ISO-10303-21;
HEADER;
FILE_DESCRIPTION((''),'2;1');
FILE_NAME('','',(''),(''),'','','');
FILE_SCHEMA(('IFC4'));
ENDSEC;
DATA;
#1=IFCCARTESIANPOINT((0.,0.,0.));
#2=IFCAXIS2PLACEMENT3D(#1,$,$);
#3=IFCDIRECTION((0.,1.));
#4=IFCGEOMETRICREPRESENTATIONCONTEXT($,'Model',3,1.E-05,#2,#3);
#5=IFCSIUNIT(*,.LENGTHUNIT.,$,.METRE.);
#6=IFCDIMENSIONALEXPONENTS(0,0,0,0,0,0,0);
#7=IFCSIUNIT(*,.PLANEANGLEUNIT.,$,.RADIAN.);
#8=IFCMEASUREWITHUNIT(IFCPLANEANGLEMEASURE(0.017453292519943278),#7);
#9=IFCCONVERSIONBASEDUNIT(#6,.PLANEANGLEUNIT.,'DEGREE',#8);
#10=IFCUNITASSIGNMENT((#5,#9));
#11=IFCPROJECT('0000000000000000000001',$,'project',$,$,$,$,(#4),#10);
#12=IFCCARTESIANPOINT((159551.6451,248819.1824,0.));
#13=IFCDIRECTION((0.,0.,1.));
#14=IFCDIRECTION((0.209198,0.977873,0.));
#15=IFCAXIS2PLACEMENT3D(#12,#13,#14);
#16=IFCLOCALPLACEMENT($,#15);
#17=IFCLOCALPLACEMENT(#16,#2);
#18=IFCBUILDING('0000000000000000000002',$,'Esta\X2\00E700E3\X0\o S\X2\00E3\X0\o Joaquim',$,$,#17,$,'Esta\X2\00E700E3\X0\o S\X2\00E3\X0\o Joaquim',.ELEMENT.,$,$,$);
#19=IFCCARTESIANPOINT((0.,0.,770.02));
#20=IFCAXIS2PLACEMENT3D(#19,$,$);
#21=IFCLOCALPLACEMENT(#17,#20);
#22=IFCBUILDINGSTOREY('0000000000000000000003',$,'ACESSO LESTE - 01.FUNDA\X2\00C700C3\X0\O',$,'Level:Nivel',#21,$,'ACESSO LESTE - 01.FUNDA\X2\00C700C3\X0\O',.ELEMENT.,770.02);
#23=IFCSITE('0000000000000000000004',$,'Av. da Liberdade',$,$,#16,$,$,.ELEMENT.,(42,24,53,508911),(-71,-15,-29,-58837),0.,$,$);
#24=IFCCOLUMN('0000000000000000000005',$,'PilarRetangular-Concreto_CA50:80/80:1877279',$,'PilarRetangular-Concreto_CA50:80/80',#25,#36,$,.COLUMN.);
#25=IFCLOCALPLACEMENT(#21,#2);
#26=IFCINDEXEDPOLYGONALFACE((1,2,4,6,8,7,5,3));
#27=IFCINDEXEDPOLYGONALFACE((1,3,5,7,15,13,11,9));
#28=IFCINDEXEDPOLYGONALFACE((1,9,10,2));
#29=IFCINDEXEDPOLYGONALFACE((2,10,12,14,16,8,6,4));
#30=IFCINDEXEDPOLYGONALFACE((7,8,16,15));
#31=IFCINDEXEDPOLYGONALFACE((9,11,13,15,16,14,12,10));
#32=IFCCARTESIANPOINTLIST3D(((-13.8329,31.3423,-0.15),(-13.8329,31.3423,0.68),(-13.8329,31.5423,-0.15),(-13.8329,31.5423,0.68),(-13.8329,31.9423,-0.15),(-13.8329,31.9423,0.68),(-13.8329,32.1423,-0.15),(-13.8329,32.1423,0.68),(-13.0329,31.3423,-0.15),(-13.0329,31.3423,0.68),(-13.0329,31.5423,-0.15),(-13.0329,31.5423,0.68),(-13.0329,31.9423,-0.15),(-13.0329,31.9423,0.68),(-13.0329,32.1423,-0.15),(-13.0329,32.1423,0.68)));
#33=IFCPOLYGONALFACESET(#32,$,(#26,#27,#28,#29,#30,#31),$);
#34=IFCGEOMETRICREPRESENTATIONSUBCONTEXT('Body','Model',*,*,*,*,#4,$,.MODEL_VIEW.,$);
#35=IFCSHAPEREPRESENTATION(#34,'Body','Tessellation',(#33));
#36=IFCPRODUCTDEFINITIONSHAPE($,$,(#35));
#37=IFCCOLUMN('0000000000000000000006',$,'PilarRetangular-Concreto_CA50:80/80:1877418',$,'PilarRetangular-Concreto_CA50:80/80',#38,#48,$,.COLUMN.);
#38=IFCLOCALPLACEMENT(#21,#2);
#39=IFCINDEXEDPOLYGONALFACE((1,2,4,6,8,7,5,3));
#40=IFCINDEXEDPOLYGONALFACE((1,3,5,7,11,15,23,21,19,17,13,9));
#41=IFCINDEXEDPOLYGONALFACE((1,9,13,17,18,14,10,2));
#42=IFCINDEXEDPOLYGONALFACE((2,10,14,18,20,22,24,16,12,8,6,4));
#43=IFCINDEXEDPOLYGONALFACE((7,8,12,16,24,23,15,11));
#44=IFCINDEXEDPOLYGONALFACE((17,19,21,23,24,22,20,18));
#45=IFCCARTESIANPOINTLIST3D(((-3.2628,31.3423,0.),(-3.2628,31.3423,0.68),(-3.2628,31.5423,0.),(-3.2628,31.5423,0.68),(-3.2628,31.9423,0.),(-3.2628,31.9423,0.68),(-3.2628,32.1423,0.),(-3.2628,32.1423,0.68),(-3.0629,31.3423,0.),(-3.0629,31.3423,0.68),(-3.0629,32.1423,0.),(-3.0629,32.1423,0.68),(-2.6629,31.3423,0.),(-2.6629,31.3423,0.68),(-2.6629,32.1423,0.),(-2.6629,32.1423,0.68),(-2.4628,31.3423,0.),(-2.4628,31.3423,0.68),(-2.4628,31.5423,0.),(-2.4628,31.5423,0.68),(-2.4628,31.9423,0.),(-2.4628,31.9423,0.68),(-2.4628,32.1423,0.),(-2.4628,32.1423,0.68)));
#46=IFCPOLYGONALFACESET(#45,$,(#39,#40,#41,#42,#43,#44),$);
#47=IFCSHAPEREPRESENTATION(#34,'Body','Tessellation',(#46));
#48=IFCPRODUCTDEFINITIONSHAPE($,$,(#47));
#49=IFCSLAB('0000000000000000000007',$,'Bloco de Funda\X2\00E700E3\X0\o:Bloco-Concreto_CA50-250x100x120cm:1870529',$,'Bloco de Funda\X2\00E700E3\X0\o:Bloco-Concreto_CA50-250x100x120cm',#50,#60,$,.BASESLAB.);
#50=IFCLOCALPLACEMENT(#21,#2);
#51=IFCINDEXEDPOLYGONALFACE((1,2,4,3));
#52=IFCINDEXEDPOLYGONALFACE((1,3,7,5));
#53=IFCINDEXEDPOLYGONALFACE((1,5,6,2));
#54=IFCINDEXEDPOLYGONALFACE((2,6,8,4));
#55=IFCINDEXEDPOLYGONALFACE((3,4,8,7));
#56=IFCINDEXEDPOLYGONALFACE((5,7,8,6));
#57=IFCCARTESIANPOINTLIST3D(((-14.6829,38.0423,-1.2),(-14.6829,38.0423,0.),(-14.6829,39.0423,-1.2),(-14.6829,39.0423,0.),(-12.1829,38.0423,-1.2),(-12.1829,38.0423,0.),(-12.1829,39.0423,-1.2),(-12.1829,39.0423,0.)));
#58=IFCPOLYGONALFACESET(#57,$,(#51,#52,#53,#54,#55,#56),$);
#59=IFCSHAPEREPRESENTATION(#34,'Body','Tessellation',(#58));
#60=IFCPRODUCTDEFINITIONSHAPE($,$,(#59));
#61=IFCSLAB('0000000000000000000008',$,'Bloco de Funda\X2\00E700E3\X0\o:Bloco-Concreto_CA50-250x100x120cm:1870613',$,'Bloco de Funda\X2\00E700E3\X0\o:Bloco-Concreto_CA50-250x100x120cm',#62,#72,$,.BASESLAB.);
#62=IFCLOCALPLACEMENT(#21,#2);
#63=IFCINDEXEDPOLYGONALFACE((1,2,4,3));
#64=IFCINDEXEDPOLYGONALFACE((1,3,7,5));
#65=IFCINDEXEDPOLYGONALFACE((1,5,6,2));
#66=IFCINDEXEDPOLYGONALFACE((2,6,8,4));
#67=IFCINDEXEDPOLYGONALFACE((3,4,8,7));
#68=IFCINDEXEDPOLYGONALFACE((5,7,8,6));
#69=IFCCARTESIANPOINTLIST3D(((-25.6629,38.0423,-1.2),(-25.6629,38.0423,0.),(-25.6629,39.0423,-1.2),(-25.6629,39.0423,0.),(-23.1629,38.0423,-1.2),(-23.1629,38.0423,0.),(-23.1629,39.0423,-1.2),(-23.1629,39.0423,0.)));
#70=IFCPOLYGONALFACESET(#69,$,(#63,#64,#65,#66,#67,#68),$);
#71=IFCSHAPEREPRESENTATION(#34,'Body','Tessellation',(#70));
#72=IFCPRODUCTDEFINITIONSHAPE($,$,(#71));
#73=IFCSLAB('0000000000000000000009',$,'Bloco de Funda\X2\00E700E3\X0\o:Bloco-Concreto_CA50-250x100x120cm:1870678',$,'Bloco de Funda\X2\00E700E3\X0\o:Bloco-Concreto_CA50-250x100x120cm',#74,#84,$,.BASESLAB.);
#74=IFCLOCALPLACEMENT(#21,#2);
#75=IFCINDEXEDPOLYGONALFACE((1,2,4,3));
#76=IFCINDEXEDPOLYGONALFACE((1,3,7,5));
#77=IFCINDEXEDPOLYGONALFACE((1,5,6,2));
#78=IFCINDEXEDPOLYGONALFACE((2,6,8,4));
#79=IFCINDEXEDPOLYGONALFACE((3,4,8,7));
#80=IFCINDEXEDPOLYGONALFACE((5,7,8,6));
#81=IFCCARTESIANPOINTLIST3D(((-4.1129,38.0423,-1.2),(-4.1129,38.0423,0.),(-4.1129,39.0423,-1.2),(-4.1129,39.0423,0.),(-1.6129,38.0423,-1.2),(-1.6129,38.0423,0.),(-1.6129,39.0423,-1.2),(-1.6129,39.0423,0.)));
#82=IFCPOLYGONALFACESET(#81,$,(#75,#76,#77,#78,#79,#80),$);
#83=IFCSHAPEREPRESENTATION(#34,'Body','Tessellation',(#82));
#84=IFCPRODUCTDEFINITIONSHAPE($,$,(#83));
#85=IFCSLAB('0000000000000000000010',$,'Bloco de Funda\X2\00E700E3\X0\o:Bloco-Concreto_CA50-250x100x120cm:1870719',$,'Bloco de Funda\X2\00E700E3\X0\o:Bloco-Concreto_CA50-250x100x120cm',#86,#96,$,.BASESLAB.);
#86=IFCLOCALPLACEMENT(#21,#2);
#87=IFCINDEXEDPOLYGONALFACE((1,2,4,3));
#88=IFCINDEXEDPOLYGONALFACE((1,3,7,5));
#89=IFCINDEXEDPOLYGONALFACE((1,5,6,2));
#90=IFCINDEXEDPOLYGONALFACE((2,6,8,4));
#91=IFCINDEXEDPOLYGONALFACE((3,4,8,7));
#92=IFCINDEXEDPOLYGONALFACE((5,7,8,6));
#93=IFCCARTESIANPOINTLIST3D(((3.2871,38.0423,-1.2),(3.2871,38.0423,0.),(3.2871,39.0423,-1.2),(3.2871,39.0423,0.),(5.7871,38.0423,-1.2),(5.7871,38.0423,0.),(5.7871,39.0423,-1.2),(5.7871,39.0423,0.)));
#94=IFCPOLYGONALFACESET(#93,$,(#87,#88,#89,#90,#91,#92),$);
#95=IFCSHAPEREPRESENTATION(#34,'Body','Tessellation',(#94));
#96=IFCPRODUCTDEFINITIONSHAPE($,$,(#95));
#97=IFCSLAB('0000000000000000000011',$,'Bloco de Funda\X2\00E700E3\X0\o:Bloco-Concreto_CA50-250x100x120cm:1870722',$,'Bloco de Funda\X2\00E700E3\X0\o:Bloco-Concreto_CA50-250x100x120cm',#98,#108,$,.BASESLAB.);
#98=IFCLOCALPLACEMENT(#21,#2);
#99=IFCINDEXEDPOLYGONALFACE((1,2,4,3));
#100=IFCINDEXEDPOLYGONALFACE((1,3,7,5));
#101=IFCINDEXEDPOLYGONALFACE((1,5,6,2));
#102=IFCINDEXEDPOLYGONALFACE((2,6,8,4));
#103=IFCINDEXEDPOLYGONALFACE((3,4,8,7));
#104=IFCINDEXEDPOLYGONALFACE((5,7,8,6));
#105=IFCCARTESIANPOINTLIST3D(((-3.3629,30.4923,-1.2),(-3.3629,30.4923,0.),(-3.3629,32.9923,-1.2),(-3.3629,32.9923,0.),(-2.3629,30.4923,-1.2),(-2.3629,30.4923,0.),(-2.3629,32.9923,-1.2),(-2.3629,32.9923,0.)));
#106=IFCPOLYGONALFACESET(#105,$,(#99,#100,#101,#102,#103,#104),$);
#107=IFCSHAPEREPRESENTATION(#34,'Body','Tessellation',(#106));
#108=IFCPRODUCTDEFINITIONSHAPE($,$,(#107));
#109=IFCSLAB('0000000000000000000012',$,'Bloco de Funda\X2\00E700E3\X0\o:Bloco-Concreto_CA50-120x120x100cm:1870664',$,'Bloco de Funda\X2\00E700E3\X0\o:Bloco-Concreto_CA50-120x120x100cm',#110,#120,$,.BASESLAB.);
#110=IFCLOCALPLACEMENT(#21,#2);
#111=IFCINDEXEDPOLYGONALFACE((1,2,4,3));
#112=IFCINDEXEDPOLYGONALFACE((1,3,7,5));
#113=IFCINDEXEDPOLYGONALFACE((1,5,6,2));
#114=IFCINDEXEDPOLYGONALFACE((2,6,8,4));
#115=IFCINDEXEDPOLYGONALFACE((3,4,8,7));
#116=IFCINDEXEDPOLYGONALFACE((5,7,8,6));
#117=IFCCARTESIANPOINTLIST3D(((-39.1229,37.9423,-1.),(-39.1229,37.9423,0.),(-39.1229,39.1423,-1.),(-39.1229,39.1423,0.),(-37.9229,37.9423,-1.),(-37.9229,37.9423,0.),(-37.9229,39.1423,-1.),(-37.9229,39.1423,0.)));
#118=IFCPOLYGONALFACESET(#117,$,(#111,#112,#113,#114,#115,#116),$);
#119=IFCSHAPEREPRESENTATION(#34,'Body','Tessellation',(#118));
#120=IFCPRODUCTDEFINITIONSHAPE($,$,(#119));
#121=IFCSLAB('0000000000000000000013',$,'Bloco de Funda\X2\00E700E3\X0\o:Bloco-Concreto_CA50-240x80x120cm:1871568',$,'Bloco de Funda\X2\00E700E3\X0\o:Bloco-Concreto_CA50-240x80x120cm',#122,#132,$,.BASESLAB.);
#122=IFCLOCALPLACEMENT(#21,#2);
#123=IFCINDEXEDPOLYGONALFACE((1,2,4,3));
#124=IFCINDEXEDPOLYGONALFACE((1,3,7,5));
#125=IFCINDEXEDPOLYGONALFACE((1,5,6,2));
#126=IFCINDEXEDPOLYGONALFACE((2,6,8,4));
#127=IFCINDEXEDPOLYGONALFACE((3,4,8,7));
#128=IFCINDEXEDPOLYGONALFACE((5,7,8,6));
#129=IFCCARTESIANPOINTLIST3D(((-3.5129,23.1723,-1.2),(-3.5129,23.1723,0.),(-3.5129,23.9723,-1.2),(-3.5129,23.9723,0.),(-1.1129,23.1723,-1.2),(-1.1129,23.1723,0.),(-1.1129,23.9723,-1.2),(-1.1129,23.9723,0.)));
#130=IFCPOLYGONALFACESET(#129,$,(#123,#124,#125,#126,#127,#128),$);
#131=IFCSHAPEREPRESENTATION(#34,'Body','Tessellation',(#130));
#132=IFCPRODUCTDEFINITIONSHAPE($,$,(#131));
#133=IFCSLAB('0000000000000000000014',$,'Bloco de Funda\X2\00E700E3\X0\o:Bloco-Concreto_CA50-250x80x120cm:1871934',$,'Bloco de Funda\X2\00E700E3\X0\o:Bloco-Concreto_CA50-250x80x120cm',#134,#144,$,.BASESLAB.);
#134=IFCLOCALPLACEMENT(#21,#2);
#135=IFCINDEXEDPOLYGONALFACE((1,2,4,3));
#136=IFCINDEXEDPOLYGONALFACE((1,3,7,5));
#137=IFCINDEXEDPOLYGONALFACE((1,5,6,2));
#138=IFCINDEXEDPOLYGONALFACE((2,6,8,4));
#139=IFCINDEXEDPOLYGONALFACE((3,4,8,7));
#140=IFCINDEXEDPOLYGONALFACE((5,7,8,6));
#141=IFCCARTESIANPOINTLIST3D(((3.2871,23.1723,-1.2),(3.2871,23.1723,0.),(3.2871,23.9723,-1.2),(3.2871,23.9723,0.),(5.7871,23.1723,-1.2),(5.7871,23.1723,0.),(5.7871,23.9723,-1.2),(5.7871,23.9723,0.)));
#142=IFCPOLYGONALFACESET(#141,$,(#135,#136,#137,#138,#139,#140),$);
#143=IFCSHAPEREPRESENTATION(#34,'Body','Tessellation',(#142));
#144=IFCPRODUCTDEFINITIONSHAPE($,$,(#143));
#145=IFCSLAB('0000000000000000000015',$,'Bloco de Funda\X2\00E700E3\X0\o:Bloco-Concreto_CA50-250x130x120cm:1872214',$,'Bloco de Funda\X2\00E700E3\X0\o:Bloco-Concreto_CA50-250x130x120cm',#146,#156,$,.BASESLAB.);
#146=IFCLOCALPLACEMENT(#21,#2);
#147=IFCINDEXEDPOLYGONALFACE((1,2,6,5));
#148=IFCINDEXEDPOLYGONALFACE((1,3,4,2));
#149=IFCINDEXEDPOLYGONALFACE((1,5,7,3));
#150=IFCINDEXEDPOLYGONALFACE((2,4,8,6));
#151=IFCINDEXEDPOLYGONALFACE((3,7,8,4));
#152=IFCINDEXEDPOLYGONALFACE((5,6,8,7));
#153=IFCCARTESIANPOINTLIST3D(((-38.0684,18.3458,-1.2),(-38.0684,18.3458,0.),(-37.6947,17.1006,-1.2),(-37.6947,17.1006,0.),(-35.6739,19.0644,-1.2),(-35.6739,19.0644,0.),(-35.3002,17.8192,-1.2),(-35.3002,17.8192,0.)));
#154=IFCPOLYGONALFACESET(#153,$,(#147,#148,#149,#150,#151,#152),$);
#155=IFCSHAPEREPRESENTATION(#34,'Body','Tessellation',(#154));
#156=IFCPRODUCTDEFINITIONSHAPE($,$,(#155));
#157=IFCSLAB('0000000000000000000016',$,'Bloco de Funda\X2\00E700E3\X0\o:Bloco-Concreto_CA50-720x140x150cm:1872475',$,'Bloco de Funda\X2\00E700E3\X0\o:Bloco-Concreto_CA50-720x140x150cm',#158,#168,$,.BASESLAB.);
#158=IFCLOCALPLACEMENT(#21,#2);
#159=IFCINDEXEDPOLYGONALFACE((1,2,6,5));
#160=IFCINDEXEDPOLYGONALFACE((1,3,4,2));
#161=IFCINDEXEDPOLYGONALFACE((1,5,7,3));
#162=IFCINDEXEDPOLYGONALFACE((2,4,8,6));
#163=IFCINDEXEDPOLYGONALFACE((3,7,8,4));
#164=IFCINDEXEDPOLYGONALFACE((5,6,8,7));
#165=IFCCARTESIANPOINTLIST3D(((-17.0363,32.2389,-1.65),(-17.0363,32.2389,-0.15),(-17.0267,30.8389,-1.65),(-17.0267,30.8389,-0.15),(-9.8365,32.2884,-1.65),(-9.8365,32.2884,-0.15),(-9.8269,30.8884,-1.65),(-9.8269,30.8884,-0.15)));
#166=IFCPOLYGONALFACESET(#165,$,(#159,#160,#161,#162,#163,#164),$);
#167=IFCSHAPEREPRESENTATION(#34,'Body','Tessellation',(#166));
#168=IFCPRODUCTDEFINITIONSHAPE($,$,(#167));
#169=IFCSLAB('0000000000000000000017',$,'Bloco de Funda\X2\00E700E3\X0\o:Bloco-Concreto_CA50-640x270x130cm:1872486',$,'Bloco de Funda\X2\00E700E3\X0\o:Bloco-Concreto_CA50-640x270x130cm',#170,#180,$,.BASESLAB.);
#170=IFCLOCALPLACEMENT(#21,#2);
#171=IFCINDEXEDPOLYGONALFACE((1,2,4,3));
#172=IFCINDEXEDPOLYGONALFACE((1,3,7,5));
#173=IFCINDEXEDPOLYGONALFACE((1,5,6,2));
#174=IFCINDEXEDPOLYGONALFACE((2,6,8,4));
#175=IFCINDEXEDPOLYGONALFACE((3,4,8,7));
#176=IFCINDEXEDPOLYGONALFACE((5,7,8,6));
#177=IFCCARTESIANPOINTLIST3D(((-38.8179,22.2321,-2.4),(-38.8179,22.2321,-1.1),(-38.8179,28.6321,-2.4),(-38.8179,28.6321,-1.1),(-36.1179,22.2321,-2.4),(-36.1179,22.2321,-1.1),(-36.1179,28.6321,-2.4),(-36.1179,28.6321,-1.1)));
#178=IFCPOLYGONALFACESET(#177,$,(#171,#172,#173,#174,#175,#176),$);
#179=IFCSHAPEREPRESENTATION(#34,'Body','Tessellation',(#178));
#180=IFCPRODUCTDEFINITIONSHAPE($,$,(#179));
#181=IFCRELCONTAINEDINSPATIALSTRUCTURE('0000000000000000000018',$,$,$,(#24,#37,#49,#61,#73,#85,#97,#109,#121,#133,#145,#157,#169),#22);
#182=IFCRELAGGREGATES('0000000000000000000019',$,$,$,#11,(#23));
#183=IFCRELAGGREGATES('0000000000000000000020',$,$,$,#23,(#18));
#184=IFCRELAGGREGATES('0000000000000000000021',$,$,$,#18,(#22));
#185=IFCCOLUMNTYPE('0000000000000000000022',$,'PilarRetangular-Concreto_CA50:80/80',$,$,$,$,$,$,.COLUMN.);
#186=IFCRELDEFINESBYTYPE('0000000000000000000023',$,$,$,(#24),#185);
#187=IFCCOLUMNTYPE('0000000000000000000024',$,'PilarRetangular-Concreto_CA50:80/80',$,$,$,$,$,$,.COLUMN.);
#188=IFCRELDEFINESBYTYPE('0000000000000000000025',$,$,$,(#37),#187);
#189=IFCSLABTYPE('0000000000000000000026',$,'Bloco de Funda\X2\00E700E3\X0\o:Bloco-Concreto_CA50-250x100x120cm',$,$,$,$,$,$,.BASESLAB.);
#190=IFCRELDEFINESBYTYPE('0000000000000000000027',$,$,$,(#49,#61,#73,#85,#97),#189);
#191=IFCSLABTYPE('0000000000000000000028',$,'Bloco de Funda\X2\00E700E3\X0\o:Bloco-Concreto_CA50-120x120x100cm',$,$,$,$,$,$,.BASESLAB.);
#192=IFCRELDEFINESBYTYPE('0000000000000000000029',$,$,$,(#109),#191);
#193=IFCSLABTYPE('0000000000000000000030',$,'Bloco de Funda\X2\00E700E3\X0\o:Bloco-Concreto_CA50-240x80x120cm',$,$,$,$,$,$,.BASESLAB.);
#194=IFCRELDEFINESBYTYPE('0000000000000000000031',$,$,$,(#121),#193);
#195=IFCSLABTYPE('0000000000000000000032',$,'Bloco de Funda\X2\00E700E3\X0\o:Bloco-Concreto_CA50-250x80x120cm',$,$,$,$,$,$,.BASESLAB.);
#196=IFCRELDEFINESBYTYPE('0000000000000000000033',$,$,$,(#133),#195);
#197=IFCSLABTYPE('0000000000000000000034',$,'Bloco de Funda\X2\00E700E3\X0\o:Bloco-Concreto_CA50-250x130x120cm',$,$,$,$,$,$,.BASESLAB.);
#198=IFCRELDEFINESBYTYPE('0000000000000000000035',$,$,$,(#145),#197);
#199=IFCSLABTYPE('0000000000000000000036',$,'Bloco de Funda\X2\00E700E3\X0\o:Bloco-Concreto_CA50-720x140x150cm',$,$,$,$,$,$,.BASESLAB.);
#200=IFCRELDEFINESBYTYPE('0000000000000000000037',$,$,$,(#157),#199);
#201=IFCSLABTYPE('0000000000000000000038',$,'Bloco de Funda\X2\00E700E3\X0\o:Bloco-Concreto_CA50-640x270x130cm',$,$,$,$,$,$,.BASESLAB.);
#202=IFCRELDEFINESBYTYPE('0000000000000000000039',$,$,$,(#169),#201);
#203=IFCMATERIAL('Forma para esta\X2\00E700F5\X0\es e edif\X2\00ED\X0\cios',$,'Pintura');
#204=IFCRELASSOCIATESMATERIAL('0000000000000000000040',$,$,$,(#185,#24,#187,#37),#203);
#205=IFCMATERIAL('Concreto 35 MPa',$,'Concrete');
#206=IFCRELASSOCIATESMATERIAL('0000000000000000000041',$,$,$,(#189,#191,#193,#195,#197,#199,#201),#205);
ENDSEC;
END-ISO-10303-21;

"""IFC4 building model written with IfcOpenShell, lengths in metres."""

from ifc_helpers import new_model, entity, si_unit, converted_unit, direction, frame, origin, place, context, subcontext, project, spatial, indexed_curve, outline, extrude, source, transform, mapped, material, type_object, type_shapes, element, save


model = new_model("IFC4")

# Units and contexts
model_context = context("Model", 3, precision=1e-05, world=origin(), true_north=direction((0.0, 1.0)))
body_context = subcontext(model_context, "Body", "Model", "MODEL_VIEW")
ifc_project = project(units=[si_unit("LENGTHUNIT", "METRE"), converted_unit("PLANEANGLEUNIT", "DEGREE", entity("IfcPlaneAngleMeasure", 0.017453292519943278), si_unit("PLANEANGLEUNIT", "RADIAN"), dimensions=[0, 0, 0, 0, 0, 0, 0])], contexts=[model_context])

# Site, building, storey
site_placement = place(None, frame((159551.6451, 248819.1824, 0.0), z_axis=(0.0, 0.0, 1.0), x_axis=(0.209198, 0.977873, 0.0)))
site = spatial("IfcSite", under=ifc_project, at=site_placement, Name="Av. da Liberdade", CompositionType="ELEMENT", RefLatitude=(42, 24, 53, 508911), RefLongitude=(-71, -15, -29, -58837), RefElevation=0.0)
building_placement = place(site_placement, origin())
building = spatial("IfcBuilding", under=site, at=building_placement, Name="Estação São Joaquim", LongName="Estação São Joaquim", CompositionType="ELEMENT")
storey_placement = place(building_placement, frame((0.0, 0.0, 770.02)))
storey = spatial("IfcBuildingStorey", under=building, at=storey_placement, Name="ACESSO LESTE - 01.FUNDAÇÃO", ObjectType="Level:Nivel", LongName="ACESSO LESTE - 01.FUNDAÇÃO", CompositionType="ELEMENT", Elevation=770.02)

# Columns
ifc_material_1 = material(Name="Concreto 35 MPa", Category="Concrete")
ifc_material_2 = material(Name="Forma para estações e edifícios", Category="Pintura")
column_type_1 = type_object("IfcColumnType", Name="PilarRetangular-Concreto_CA50:80/80", PredefinedType="COLUMN", material=ifc_material_2)
shared_shape_1 = source(origin(), body_context, "Body", "SweptSolid", [
    extrude(outline(indexed_curve([(-0.4, -0.4), (0.4, -0.4), (0.4, -0.2), (0.4, 0.2), (0.4, 0.4), (-0.4, 0.4), (-0.4, 0.2), (-0.4, -0.2), (-0.4, -0.4)], self_intersect=False)), frame((-13.4329, 31.7423, 769.87), z_axis=(0.0, 0.0, 1.0), x_axis=(-1.0, 0.0, 0.0)), (0.0, 0.0, 1.0), 0.83),
])
type_shapes(column_type_1, [shared_shape_1])
column_1_placement = place(storey_placement, frame((0.0, 0.0, -770.02)))
element("IfcColumn", 1, at=column_1_placement, inside=storey, type_object=column_type_1, material=ifc_material_2, Name="PilarRetangular-Concreto_CA50:80/80:1877279", ObjectType="PilarRetangular-Concreto_CA50:80/80", PredefinedType="COLUMN", context=body_context, shape_type="MappedRepresentation", body=[
    mapped(shared_shape_1, transform((0.0, 0.0, 0.0), scale=1.0)),
])
column_type_2 = type_object("IfcColumnType", Name="PilarRetangular-Concreto_CA50:80/80", PredefinedType="COLUMN", material=ifc_material_2)
shared_shape_2 = source(origin(), body_context, "Body", "SweptSolid", [
    extrude(outline(indexed_curve([(-0.4, -0.4), (-0.1999, -0.4), (0.2001, -0.4), (0.4, -0.4), (0.4, -0.2), (0.4, 0.2), (0.4, 0.4), (0.2001, 0.4), (-0.1999, 0.4), (-0.4, 0.4), (-0.4, 0.2), (-0.4, -0.2), (-0.4, -0.4)], self_intersect=False)), frame((-2.8628, 31.7423, 770.02), z_axis=(0.0, 0.0, 1.0), x_axis=(-1.0, 0.0, 0.0)), (0.0, 0.0, 1.0), 0.68),
])
type_shapes(column_type_2, [shared_shape_2])
column_2_placement = place(storey_placement, frame((0.0, 0.0, -770.02)))
element("IfcColumn", 2, at=column_2_placement, inside=storey, type_object=column_type_2, material=ifc_material_2, Name="PilarRetangular-Concreto_CA50:80/80:1877418", ObjectType="PilarRetangular-Concreto_CA50:80/80", PredefinedType="COLUMN", context=body_context, shape_type="MappedRepresentation", body=[
    mapped(shared_shape_2, transform((0.0, 0.0, 0.0), scale=1.0)),
])

# Slabs
slab_type_1 = type_object("IfcSlabType", Name="Bloco de Fundação:Bloco-Concreto_CA50-250x100x120cm", PredefinedType="BASESLAB", material=ifc_material_1)
slab_1_placement = place(storey_placement, origin())
element("IfcSlab", 3, at=slab_1_placement, inside=storey, type_object=slab_type_1, Name="Bloco de Fundação:Bloco-Concreto_CA50-250x100x120cm:1870529", ObjectType="Bloco de Fundação:Bloco-Concreto_CA50-250x100x120cm", PredefinedType="BASESLAB", context=body_context, shape_type="SweptSolid", body=[
    extrude(outline(indexed_curve([(-0.5, -1.25), (0.5, -1.25), (0.5, 1.25), (-0.5, 1.25), (-0.5, -1.25)], self_intersect=False)), frame((-13.4329, 38.5423, -1.2), z_axis=(0.0, 0.0, 1.0), x_axis=(0.0, 1.0, 0.0)), (0.0, 0.0, 1.0), 1.2),
])
slab_2_placement = place(storey_placement, origin())
element("IfcSlab", 4, at=slab_2_placement, inside=storey, type_object=slab_type_1, Name="Bloco de Fundação:Bloco-Concreto_CA50-250x100x120cm:1870613", ObjectType="Bloco de Fundação:Bloco-Concreto_CA50-250x100x120cm", PredefinedType="BASESLAB", context=body_context, shape_type="SweptSolid", body=[
    extrude(outline(indexed_curve([(-0.5, -1.25), (0.5, -1.25), (0.5, 1.25), (-0.5, 1.25), (-0.5, -1.25)], self_intersect=False)), frame((-24.4129, 38.5423, -1.2), z_axis=(0.0, 0.0, 1.0), x_axis=(0.0, 1.0, 0.0)), (0.0, 0.0, 1.0), 1.2),
])
slab_3_placement = place(storey_placement, origin())
element("IfcSlab", 5, at=slab_3_placement, inside=storey, type_object=slab_type_1, Name="Bloco de Fundação:Bloco-Concreto_CA50-250x100x120cm:1870678", ObjectType="Bloco de Fundação:Bloco-Concreto_CA50-250x100x120cm", PredefinedType="BASESLAB", context=body_context, shape_type="SweptSolid", body=[
    extrude(outline(indexed_curve([(-0.5, -1.25), (0.5, -1.25), (0.5, 1.25), (-0.5, 1.25), (-0.5, -1.25)], self_intersect=False)), frame((-2.8629, 38.5423, -1.2), z_axis=(0.0, 0.0, 1.0), x_axis=(0.0, -1.0, 0.0)), (0.0, 0.0, 1.0), 1.2),
])
slab_4_placement = place(storey_placement, origin())
element("IfcSlab", 6, at=slab_4_placement, inside=storey, type_object=slab_type_1, Name="Bloco de Fundação:Bloco-Concreto_CA50-250x100x120cm:1870719", ObjectType="Bloco de Fundação:Bloco-Concreto_CA50-250x100x120cm", PredefinedType="BASESLAB", context=body_context, shape_type="SweptSolid", body=[
    extrude(outline(indexed_curve([(-0.5, -1.25), (0.5, -1.25), (0.5, 1.25), (-0.5, 1.25), (-0.5, -1.25)], self_intersect=False)), frame((4.5371, 38.5423, -1.2), z_axis=(0.0, 0.0, 1.0), x_axis=(0.0, -1.0, 0.0)), (0.0, 0.0, 1.0), 1.2),
])
slab_5_placement = place(storey_placement, origin())
element("IfcSlab", 7, at=slab_5_placement, inside=storey, type_object=slab_type_1, Name="Bloco de Fundação:Bloco-Concreto_CA50-250x100x120cm:1870722", ObjectType="Bloco de Fundação:Bloco-Concreto_CA50-250x100x120cm", PredefinedType="BASESLAB", context=body_context, shape_type="SweptSolid", body=[
    extrude(outline(indexed_curve([(-0.5, -1.25), (0.5, -1.25), (0.5, 1.25), (-0.5, 1.25), (-0.5, -1.25)], self_intersect=False)), frame((-2.8629, 31.7423, -1.2)), (0.0, 0.0, 1.0), 1.2),
])
slab_type_2 = type_object("IfcSlabType", Name="Bloco de Fundação:Bloco-Concreto_CA50-120x120x100cm", PredefinedType="BASESLAB", material=ifc_material_1)
slab_6_placement = place(storey_placement, origin())
element("IfcSlab", 8, at=slab_6_placement, inside=storey, type_object=slab_type_2, Name="Bloco de Fundação:Bloco-Concreto_CA50-120x120x100cm:1870664", ObjectType="Bloco de Fundação:Bloco-Concreto_CA50-120x120x100cm", PredefinedType="BASESLAB", context=body_context, shape_type="SweptSolid", body=[
    extrude(outline(indexed_curve([(-0.6, -0.6), (0.6, -0.6), (0.6, 0.6), (-0.6, 0.6), (-0.6, -0.6)], self_intersect=False)), frame((-38.5229, 38.5423, -1.0), z_axis=(0.0, 0.0, 1.0), x_axis=(-1.0, 0.0, 0.0)), (0.0, 0.0, 1.0), 1.0),
])
slab_type_3 = type_object("IfcSlabType", Name="Bloco de Fundação:Bloco-Concreto_CA50-240x80x120cm", PredefinedType="BASESLAB", material=ifc_material_1)
slab_7_placement = place(storey_placement, origin())
element("IfcSlab", 9, at=slab_7_placement, inside=storey, type_object=slab_type_3, Name="Bloco de Fundação:Bloco-Concreto_CA50-240x80x120cm:1871568", ObjectType="Bloco de Fundação:Bloco-Concreto_CA50-240x80x120cm", PredefinedType="BASESLAB", context=body_context, shape_type="SweptSolid", body=[
    extrude(outline(indexed_curve([(-0.4, -1.2), (0.4, -1.2), (0.4, 1.2), (-0.4, 1.2), (-0.4, -1.2)], self_intersect=False)), frame((-2.3129, 23.5723, -1.2), z_axis=(0.0, 0.0, 1.0), x_axis=(0.0, -1.0, 0.0)), (0.0, 0.0, 1.0), 1.2),
])
slab_type_4 = type_object("IfcSlabType", Name="Bloco de Fundação:Bloco-Concreto_CA50-250x80x120cm", PredefinedType="BASESLAB", material=ifc_material_1)
slab_8_placement = place(storey_placement, origin())
element("IfcSlab", 10, at=slab_8_placement, inside=storey, type_object=slab_type_4, Name="Bloco de Fundação:Bloco-Concreto_CA50-250x80x120cm:1871934", ObjectType="Bloco de Fundação:Bloco-Concreto_CA50-250x80x120cm", PredefinedType="BASESLAB", context=body_context, shape_type="SweptSolid", body=[
    extrude(outline(indexed_curve([(-0.4, -1.25), (0.4, -1.25), (0.4, 1.25), (-0.4, 1.25), (-0.4, -1.25)], self_intersect=False)), frame((4.5371, 23.5723, -1.2), z_axis=(0.0, 0.0, 1.0), x_axis=(0.0, -1.0, 0.0)), (0.0, 0.0, 1.0), 1.2),
])
slab_type_5 = type_object("IfcSlabType", Name="Bloco de Fundação:Bloco-Concreto_CA50-250x130x120cm", PredefinedType="BASESLAB", material=ifc_material_1)
slab_9_placement = place(storey_placement, origin())
element("IfcSlab", 11, at=slab_9_placement, inside=storey, type_object=slab_type_5, Name="Bloco de Fundação:Bloco-Concreto_CA50-250x130x120cm:1872214", ObjectType="Bloco de Fundação:Bloco-Concreto_CA50-250x130x120cm", PredefinedType="BASESLAB", context=body_context, shape_type="SweptSolid", body=[
    extrude(outline(indexed_curve([(-0.65, -1.25), (0.65, -1.25), (0.65, 1.25), (-0.65, 1.25), (-0.65, -1.25)], self_intersect=False)), frame((-36.6843, 18.0825, -1.2), z_axis=(0.0, 0.0, 1.0), x_axis=(-0.287438, 0.957799, 0.0)), (0.0, 0.0, 1.0), 1.2),
])
slab_type_6 = type_object("IfcSlabType", Name="Bloco de Fundação:Bloco-Concreto_CA50-720x140x150cm", PredefinedType="BASESLAB", material=ifc_material_1)
slab_10_placement = place(storey_placement, frame((0.0, 0.0, -0.15)))
element("IfcSlab", 12, at=slab_10_placement, inside=storey, type_object=slab_type_6, Name="Bloco de Fundação:Bloco-Concreto_CA50-720x140x150cm:1872475", ObjectType="Bloco de Fundação:Bloco-Concreto_CA50-720x140x150cm", PredefinedType="BASESLAB", context=body_context, shape_type="SweptSolid", body=[
    extrude(outline(indexed_curve([(-0.7, -3.6), (0.7, -3.6), (0.7, 3.6), (-0.7, 3.6), (-0.7, -3.6)], self_intersect=False)), frame((-13.4316, 31.5637, -1.5), z_axis=(0.0, 0.0, 1.0), x_axis=(0.006867, -0.999976, 0.0)), (0.0, 0.0, 1.0), 1.5),
])
slab_type_7 = type_object("IfcSlabType", Name="Bloco de Fundação:Bloco-Concreto_CA50-640x270x130cm", PredefinedType="BASESLAB", material=ifc_material_1)
slab_11_placement = place(storey_placement, frame((0.0, 0.0, -1.1)))
element("IfcSlab", 13, at=slab_11_placement, inside=storey, type_object=slab_type_7, Name="Bloco de Fundação:Bloco-Concreto_CA50-640x270x130cm:1872486", ObjectType="Bloco de Fundação:Bloco-Concreto_CA50-640x270x130cm", PredefinedType="BASESLAB", context=body_context, shape_type="SweptSolid", body=[
    extrude(outline(indexed_curve([(-1.35, -3.2), (1.35, -3.2), (1.35, 3.2), (-1.35, 3.2), (-1.35, -3.2)], self_intersect=False)), frame((-37.4679, 25.4321, -1.3), z_axis=(0.0, 0.0, 1.0), x_axis=(-1.0, 0.0, 0.0)), (0.0, 0.0, 1.0), 1.3),
])

save(model, "model.ifc")
